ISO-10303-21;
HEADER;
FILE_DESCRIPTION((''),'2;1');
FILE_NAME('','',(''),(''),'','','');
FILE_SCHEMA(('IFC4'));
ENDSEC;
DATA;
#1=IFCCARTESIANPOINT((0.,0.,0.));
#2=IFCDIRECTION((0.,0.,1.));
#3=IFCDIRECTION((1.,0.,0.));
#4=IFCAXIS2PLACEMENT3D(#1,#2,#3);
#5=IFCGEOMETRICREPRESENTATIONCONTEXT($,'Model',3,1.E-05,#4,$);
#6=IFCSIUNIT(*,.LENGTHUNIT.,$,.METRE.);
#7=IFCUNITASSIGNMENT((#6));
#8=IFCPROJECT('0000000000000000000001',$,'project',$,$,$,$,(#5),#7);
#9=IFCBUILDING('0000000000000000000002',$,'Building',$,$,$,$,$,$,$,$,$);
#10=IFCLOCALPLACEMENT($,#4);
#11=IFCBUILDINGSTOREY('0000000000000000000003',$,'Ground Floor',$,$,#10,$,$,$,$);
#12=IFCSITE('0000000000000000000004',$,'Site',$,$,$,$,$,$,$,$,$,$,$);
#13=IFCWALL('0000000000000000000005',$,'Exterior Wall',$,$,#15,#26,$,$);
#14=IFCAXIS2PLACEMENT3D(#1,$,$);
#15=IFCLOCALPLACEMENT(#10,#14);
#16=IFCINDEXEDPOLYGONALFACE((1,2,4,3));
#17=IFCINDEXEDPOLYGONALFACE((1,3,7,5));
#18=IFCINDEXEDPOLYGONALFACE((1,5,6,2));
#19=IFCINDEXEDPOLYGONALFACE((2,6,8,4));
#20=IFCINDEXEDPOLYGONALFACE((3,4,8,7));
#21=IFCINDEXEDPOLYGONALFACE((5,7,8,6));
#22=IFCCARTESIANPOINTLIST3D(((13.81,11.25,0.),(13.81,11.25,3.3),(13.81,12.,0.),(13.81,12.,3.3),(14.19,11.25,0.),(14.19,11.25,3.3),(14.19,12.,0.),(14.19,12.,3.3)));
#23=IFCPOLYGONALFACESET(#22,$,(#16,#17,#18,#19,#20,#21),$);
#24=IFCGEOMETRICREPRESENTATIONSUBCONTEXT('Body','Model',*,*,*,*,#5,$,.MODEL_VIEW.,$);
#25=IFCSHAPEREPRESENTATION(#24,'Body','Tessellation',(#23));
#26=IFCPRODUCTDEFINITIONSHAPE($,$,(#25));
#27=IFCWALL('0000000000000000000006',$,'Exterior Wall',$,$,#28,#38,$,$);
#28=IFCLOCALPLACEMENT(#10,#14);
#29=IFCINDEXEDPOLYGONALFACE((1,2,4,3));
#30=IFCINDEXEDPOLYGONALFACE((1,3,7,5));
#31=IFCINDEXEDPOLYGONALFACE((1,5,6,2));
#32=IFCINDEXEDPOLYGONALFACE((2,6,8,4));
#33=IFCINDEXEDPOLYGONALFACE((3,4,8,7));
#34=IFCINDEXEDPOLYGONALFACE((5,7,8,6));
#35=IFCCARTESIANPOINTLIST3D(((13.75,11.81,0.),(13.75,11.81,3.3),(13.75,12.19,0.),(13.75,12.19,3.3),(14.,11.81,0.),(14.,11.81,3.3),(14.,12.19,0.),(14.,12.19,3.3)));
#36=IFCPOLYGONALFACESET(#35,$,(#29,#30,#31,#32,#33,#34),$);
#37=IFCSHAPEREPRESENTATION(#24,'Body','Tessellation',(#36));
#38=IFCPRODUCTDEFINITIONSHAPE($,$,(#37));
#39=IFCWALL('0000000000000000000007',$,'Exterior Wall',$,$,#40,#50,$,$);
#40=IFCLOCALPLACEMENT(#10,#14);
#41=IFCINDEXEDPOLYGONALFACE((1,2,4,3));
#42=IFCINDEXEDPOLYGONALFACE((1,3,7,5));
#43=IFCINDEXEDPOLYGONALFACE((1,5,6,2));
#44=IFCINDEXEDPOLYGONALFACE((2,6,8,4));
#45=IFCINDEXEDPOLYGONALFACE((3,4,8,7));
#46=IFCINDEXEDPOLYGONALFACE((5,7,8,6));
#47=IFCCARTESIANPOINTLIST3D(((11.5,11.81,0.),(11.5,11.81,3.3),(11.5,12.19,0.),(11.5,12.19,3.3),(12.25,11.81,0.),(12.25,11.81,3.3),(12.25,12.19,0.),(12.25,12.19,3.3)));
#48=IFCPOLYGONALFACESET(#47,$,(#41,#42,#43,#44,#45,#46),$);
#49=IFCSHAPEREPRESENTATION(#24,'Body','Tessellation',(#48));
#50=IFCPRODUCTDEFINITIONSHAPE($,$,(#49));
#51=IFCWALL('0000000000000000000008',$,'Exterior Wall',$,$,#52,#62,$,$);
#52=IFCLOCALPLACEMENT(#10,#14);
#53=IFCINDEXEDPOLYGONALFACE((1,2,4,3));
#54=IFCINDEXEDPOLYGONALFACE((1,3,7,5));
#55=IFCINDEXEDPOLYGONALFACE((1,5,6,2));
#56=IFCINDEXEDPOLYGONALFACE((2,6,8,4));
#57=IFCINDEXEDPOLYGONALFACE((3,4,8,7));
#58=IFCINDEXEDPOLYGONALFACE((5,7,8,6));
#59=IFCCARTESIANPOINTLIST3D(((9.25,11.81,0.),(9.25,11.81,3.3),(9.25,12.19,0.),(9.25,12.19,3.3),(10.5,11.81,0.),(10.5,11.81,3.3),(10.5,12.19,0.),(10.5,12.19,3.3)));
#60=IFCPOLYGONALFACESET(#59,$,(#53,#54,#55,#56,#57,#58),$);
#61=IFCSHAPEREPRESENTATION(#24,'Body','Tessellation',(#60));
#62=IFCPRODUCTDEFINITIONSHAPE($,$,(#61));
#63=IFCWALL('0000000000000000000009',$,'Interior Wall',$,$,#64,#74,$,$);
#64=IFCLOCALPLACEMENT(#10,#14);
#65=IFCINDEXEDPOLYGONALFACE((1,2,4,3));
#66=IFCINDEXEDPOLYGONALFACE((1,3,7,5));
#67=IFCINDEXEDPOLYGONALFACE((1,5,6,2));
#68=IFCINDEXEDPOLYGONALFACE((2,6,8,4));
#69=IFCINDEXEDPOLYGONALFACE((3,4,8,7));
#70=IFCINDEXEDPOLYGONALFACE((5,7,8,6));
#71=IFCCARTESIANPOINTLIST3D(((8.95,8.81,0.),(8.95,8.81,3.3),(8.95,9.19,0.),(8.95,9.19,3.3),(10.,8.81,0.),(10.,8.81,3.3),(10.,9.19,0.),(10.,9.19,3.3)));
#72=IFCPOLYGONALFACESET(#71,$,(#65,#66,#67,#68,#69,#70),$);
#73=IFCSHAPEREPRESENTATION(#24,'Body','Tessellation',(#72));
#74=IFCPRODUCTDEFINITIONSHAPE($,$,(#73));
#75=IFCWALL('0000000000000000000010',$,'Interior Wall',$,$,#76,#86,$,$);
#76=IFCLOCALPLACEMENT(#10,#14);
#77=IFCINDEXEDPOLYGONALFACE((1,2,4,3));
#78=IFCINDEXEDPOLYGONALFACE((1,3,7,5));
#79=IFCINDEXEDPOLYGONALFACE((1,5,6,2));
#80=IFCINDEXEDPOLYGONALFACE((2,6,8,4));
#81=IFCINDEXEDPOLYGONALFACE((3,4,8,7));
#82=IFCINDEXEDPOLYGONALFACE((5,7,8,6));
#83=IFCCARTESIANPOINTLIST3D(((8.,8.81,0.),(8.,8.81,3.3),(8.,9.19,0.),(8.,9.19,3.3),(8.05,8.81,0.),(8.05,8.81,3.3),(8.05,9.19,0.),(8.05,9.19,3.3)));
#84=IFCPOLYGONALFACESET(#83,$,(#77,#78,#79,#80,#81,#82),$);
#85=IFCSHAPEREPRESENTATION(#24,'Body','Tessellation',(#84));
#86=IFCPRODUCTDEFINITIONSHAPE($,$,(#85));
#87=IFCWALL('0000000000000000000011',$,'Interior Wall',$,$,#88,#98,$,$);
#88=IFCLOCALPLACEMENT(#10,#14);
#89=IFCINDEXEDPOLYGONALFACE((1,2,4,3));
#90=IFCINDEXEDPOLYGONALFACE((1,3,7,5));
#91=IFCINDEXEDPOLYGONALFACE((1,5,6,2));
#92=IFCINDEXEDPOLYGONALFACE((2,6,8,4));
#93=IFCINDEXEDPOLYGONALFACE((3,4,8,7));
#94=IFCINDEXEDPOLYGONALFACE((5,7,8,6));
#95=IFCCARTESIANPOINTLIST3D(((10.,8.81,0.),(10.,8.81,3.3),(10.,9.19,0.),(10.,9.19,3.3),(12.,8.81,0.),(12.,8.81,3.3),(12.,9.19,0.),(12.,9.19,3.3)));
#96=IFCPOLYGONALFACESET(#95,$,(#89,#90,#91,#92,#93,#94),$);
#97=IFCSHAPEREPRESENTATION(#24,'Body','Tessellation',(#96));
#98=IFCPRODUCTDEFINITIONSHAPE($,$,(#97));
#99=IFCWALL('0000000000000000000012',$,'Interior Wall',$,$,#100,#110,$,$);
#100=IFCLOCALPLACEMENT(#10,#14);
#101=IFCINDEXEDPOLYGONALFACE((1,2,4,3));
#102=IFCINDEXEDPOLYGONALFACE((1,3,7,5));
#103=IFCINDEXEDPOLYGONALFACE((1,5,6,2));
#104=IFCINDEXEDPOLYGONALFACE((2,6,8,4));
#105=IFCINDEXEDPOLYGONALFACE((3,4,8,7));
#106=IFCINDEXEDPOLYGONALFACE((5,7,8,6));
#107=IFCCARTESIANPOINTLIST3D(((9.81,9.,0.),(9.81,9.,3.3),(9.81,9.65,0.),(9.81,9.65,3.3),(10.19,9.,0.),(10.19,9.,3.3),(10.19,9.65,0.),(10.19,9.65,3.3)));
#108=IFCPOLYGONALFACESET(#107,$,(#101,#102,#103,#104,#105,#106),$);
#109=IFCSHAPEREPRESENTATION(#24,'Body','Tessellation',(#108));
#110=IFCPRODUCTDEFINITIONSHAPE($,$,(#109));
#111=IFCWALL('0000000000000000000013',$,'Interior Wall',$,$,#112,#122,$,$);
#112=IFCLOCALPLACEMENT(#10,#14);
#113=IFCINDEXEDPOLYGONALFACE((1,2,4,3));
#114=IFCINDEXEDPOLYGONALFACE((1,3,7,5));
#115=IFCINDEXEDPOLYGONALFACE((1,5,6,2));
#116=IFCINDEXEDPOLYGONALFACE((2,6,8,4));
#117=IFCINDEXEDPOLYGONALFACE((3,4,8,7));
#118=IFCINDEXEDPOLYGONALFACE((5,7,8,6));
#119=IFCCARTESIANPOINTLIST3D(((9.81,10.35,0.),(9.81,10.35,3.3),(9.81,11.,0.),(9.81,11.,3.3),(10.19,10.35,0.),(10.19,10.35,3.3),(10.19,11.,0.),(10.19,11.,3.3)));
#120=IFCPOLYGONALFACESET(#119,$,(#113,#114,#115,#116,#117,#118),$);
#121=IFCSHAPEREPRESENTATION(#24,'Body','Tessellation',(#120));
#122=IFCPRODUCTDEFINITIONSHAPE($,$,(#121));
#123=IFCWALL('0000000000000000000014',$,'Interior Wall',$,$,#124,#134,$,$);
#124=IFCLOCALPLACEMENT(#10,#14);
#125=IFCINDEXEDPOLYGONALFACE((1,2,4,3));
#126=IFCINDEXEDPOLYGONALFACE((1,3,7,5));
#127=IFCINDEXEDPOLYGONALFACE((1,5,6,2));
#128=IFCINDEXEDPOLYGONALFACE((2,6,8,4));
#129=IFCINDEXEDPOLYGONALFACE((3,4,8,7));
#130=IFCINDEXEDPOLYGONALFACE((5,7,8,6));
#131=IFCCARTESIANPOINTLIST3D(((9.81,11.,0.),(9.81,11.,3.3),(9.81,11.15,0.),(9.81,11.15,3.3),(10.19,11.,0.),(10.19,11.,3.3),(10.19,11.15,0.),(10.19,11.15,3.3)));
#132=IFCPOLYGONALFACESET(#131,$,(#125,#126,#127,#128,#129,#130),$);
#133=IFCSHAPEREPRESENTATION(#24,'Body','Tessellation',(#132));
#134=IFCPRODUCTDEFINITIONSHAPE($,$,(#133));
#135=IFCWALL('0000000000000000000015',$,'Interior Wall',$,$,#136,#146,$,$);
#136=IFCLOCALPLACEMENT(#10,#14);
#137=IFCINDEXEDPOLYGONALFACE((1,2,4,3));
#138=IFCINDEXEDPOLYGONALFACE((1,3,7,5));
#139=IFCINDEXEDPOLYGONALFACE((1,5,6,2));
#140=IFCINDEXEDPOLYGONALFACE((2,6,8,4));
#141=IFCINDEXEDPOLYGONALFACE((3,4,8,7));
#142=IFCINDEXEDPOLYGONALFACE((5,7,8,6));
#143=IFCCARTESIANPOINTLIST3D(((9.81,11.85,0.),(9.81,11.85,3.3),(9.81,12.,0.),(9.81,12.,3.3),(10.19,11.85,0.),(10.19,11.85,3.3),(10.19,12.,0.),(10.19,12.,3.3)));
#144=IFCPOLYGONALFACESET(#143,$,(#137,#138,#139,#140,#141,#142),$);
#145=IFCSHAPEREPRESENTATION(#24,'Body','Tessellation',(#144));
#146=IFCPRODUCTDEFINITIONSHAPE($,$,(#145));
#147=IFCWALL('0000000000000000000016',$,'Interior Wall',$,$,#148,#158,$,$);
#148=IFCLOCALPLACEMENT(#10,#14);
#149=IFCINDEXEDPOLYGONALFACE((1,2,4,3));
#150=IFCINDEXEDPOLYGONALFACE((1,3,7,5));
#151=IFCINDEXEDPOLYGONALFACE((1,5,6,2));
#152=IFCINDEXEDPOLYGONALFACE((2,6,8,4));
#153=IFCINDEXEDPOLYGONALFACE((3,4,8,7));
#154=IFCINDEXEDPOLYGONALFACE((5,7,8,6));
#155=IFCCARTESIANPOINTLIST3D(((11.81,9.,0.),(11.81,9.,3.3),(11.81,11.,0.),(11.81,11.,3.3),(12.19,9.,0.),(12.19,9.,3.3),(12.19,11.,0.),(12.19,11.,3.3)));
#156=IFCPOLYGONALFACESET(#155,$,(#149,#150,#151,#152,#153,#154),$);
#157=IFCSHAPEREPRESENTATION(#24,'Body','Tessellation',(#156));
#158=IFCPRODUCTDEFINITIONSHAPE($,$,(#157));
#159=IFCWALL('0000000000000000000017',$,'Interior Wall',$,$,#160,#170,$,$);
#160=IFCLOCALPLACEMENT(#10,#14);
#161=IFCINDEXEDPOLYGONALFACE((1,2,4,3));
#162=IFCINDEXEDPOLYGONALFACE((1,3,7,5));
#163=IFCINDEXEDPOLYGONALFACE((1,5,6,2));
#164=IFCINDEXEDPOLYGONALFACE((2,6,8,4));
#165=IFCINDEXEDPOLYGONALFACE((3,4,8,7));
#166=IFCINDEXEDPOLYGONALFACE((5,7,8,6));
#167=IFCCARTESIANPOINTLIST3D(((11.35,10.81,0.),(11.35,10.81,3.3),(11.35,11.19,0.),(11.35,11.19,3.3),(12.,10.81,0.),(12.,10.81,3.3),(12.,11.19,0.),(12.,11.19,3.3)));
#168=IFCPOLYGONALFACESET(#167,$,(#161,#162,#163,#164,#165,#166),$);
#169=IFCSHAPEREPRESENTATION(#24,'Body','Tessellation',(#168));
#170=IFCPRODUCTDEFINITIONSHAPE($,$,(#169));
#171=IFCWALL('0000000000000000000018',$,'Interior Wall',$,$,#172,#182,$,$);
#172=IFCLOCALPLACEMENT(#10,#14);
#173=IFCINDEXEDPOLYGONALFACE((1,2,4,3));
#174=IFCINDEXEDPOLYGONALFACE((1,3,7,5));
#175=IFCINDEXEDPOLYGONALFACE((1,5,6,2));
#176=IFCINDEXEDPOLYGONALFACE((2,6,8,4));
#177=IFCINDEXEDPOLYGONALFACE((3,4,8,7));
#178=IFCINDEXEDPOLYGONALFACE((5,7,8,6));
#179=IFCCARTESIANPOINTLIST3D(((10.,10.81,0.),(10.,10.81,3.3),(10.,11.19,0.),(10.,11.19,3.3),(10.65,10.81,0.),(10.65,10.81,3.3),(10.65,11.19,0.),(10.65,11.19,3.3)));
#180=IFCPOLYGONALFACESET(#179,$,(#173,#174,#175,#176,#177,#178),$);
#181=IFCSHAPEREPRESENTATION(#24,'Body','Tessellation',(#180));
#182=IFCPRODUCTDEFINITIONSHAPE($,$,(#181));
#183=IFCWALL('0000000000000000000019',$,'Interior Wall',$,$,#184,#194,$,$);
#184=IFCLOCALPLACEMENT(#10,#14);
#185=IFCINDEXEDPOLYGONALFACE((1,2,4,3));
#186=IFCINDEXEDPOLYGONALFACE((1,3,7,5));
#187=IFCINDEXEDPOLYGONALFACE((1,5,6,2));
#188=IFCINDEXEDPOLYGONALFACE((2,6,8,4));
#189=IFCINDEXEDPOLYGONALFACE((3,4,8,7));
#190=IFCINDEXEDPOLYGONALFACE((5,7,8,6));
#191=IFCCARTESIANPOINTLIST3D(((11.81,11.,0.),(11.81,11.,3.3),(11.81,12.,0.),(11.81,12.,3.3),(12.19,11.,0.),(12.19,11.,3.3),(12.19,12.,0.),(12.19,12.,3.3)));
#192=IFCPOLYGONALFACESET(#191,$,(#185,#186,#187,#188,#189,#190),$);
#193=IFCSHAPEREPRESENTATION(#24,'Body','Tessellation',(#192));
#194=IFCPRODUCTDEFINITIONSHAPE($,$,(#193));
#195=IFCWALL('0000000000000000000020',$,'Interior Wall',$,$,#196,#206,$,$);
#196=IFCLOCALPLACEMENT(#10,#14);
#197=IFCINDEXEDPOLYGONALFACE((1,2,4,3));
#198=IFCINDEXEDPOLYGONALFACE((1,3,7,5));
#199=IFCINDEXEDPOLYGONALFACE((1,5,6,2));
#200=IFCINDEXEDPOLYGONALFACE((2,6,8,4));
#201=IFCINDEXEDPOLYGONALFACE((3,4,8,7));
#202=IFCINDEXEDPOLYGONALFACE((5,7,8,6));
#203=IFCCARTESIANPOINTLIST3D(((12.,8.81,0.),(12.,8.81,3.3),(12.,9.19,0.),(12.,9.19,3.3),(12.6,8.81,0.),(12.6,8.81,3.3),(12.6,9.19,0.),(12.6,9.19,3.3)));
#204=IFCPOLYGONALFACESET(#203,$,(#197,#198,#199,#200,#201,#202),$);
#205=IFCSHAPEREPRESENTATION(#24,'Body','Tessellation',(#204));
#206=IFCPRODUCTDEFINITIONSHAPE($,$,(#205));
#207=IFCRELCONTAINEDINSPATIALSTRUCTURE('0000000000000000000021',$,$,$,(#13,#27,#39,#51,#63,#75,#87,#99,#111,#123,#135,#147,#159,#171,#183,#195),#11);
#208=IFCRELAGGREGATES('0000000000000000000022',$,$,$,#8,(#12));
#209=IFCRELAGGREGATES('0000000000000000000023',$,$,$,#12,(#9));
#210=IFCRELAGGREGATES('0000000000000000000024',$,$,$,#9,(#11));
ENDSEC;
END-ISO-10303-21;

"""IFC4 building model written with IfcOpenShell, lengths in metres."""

from ifc_helpers import new_model, si_unit, frame, origin_with_axes, place, context, subcontext, project, spatial, indexed_curve, outline, extrude, element, save


model = new_model("IFC4")

# Units and contexts
model_context = context("Model", 3, precision=1e-05, world=origin_with_axes())
body_context = subcontext(model_context, "Body", "Model", "MODEL_VIEW")
ifc_project = project(units=[si_unit("LENGTHUNIT", "METRE")], contexts=[model_context])

# Site, building, storey
site = spatial("IfcSite", under=ifc_project, Name="Site")
building = spatial("IfcBuilding", under=site, Name="Building")
storey_placement = place(None, origin_with_axes())
storey = spatial("IfcBuildingStorey", under=building, at=storey_placement, Name="Ground Floor")

# Walls
wall_1_placement = place(storey_placement, frame((14.0, 11.25, 0.0), z_axis=(0.0, 0.0, 1.0), x_axis=(0.0, 1.0, 0.0)))
element("IfcWall", 1, at=wall_1_placement, inside=storey, Name="Exterior Wall", context=body_context, shape_type="SweptSolid", body=[
    extrude(outline(indexed_curve([(0.0, 0.0), (0.0, 0.38), (0.75, 0.38), (0.75, 0.0), (0.0, 0.0)], self_intersect=False)), frame((0.0, -0.19, 0.0), z_axis=(0.0, 0.0, 1.0), x_axis=(1.0, 0.0, 0.0)), (0.0, 0.0, 1.0), 3.3),
])
wall_2_placement = place(storey_placement, frame((14.0, 12.0, 0.0), z_axis=(0.0, 0.0, 1.0), x_axis=(-1.0, 0.0, 0.0)))
element("IfcWall", 2, at=wall_2_placement, inside=storey, Name="Exterior Wall", context=body_context, shape_type="SweptSolid", body=[
    extrude(outline(indexed_curve([(0.0, 0.0), (0.0, 0.38), (0.25, 0.38), (0.25, 0.0), (0.0, 0.0)], self_intersect=False)), frame((0.0, -0.19, 0.0), z_axis=(0.0, 0.0, 1.0), x_axis=(1.0, 0.0, 0.0)), (0.0, 0.0, 1.0), 3.3),
])
wall_3_placement = place(storey_placement, frame((12.25, 12.0, 0.0), z_axis=(0.0, 0.0, 1.0), x_axis=(-1.0, 0.0, 0.0)))
element("IfcWall", 3, at=wall_3_placement, inside=storey, Name="Exterior Wall", context=body_context, shape_type="SweptSolid", body=[
    extrude(outline(indexed_curve([(0.0, 0.0), (0.0, 0.38), (0.75, 0.38), (0.75, 0.0), (0.0, 0.0)], self_intersect=False)), frame((0.0, -0.19, 0.0), z_axis=(0.0, 0.0, 1.0), x_axis=(1.0, 0.0, 0.0)), (0.0, 0.0, 1.0), 3.3),
])
wall_4_placement = place(storey_placement, frame((10.5, 12.0, 0.0), z_axis=(0.0, 0.0, 1.0), x_axis=(-1.0, 0.0, 0.0)))
element("IfcWall", 4, at=wall_4_placement, inside=storey, Name="Exterior Wall", context=body_context, shape_type="SweptSolid", body=[
    extrude(outline(indexed_curve([(0.0, 0.0), (0.0, 0.38), (1.25, 0.38), (1.25, 0.0), (0.0, 0.0)], self_intersect=False)), frame((0.0, -0.19, 0.0), z_axis=(0.0, 0.0, 1.0), x_axis=(1.0, 0.0, 0.0)), (0.0, 0.0, 1.0), 3.3),
])
wall_5_placement = place(storey_placement, frame((10.0, 9.0, 0.0), z_axis=(0.0, 0.0, 1.0), x_axis=(-1.0, 0.0, 0.0)))
element("IfcWall", 5, at=wall_5_placement, inside=storey, Name="Interior Wall", context=body_context, shape_type="SweptSolid", body=[
    extrude(outline(indexed_curve([(0.0, 0.0), (0.0, 0.38), (1.05, 0.38), (1.05, 0.0), (0.0, 0.0)], self_intersect=False)), frame((0.0, -0.19, 0.0), z_axis=(0.0, 0.0, 1.0), x_axis=(1.0, 0.0, 0.0)), (0.0, 0.0, 1.0), 3.3),
])
wall_6_placement = place(storey_placement, frame((8.05, 9.0, 0.0), z_axis=(0.0, 0.0, 1.0), x_axis=(-1.0, 0.0, 0.0)))
element("IfcWall", 6, at=wall_6_placement, inside=storey, Name="Interior Wall", context=body_context, shape_type="SweptSolid", body=[
    extrude(outline(indexed_curve([(0.0, 0.0), (0.0, 0.38), (0.05, 0.38), (0.05, 0.0), (0.0, 0.0)], self_intersect=False)), frame((0.0, -0.19, 0.0), z_axis=(0.0, 0.0, 1.0), x_axis=(1.0, 0.0, 0.0)), (0.0, 0.0, 1.0), 3.3),
])
wall_7_placement = place(storey_placement, frame((12.0, 9.0, 0.0), z_axis=(0.0, 0.0, 1.0), x_axis=(-1.0, 0.0, 0.0)))
element("IfcWall", 7, at=wall_7_placement, inside=storey, Name="Interior Wall", context=body_context, shape_type="SweptSolid", body=[
    extrude(outline(indexed_curve([(0.0, 0.0), (0.0, 0.38), (2.0, 0.38), (2.0, 0.0), (0.0, 0.0)], self_intersect=False)), frame((0.0, -0.19, 0.0), z_axis=(0.0, 0.0, 1.0), x_axis=(1.0, 0.0, 0.0)), (0.0, 0.0, 1.0), 3.3),
])
for number, where, z_axis, x_axis, name in (
    (8, (10.0, 9.0, 0.0), (0.0, 0.0, 1.0), (0.0, 1.0, 0.0), "Interior Wall"),
    (9, (10.0, 10.35, 0.0), (0.0, 0.0, 1.0), (0.0, 1.0, 0.0), "Interior Wall"),
):
    element("IfcWall", number, at=place(storey_placement, frame(where, z_axis=z_axis, x_axis=x_axis)), inside=storey, Name=name, context=body_context, shape_type="SweptSolid", body=[
        extrude(outline(indexed_curve([(0.0, 0.0), (0.0, 0.38), (0.65, 0.38), (0.65, 0.0), (0.0, 0.0)], self_intersect=False)), frame((0.0, -0.19, 0.0), z_axis=(0.0, 0.0, 1.0), x_axis=(1.0, 0.0, 0.0)), (0.0, 0.0, 1.0), 3.3),
    ])
for number, where, z_axis, x_axis, name in (
    (10, (10.0, 11.0, 0.0), (0.0, 0.0, 1.0), (0.0, 1.0, 0.0), "Interior Wall"),
    (11, (10.0, 11.85, 0.0), (0.0, 0.0, 1.0), (0.0, 1.0, 0.0), "Interior Wall"),
):
    element("IfcWall", number, at=place(storey_placement, frame(where, z_axis=z_axis, x_axis=x_axis)), inside=storey, Name=name, context=body_context, shape_type="SweptSolid", body=[
        extrude(outline(indexed_curve([(0.0, 0.0), (0.0, 0.38), (0.15, 0.38), (0.15, 0.0), (0.0, 0.0)], self_intersect=False)), frame((0.0, -0.19, 0.0), z_axis=(0.0, 0.0, 1.0), x_axis=(1.0, 0.0, 0.0)), (0.0, 0.0, 1.0), 3.3),
    ])
wall_8_placement = place(storey_placement, frame((12.0, 9.0, 0.0), z_axis=(0.0, 0.0, 1.0), x_axis=(0.0, 1.0, 0.0)))
element("IfcWall", 12, at=wall_8_placement, inside=storey, Name="Interior Wall", context=body_context, shape_type="SweptSolid", body=[
    extrude(outline(indexed_curve([(0.0, 0.0), (0.0, 0.38), (2.0, 0.38), (2.0, 0.0), (0.0, 0.0)], self_intersect=False)), frame((0.0, -0.19, 0.0), z_axis=(0.0, 0.0, 1.0), x_axis=(1.0, 0.0, 0.0)), (0.0, 0.0, 1.0), 3.3),
])
for number, where, z_axis, x_axis, name in (
    (13, (12.0, 11.0, 0.0), (0.0, 0.0, 1.0), (-1.0, 0.0, 0.0), "Interior Wall"),
    (14, (10.65, 11.0, 0.0), (0.0, 0.0, 1.0), (-1.0, 0.0, 0.0), "Interior Wall"),
):
    element("IfcWall", number, at=place(storey_placement, frame(where, z_axis=z_axis, x_axis=x_axis)), inside=storey, Name=name, context=body_context, shape_type="SweptSolid", body=[
        extrude(outline(indexed_curve([(0.0, 0.0), (0.0, 0.38), (0.65, 0.38), (0.65, 0.0), (0.0, 0.0)], self_intersect=False)), frame((0.0, -0.19, 0.0), z_axis=(0.0, 0.0, 1.0), x_axis=(1.0, 0.0, 0.0)), (0.0, 0.0, 1.0), 3.3),
    ])
wall_9_placement = place(storey_placement, frame((12.0, 11.0, 0.0), z_axis=(0.0, 0.0, 1.0), x_axis=(0.0, 1.0, 0.0)))
element("IfcWall", 15, at=wall_9_placement, inside=storey, Name="Interior Wall", context=body_context, shape_type="SweptSolid", body=[
    extrude(outline(indexed_curve([(0.0, 0.0), (0.0, 0.38), (1.0, 0.38), (1.0, 0.0), (0.0, 0.0)], self_intersect=False)), frame((0.0, -0.19, 0.0), z_axis=(0.0, 0.0, 1.0), x_axis=(1.0, 0.0, 0.0)), (0.0, 0.0, 1.0), 3.3),
])
for number, where, z_axis, x_axis, name in (
    (16, (12.0, 9.0, 0.0), (0.0, 0.0, 1.0), (1.0, 0.0, 0.0), "Interior Wall"),
):
    element("IfcWall", number, at=place(storey_placement, frame(where, z_axis=z_axis, x_axis=x_axis)), inside=storey, Name=name, context=body_context, shape_type="SweptSolid", body=[
        extrude(outline(indexed_curve([(0.0, 0.0), (0.0, 0.38), (0.6, 0.38), (0.6, 0.0), (0.0, 0.0)], self_intersect=False)), frame((0.0, -0.19, 0.0), z_axis=(0.0, 0.0, 1.0), x_axis=(1.0, 0.0, 0.0)), (0.0, 0.0, 1.0), 3.3),
    ])

save(model, "model.ifc")
